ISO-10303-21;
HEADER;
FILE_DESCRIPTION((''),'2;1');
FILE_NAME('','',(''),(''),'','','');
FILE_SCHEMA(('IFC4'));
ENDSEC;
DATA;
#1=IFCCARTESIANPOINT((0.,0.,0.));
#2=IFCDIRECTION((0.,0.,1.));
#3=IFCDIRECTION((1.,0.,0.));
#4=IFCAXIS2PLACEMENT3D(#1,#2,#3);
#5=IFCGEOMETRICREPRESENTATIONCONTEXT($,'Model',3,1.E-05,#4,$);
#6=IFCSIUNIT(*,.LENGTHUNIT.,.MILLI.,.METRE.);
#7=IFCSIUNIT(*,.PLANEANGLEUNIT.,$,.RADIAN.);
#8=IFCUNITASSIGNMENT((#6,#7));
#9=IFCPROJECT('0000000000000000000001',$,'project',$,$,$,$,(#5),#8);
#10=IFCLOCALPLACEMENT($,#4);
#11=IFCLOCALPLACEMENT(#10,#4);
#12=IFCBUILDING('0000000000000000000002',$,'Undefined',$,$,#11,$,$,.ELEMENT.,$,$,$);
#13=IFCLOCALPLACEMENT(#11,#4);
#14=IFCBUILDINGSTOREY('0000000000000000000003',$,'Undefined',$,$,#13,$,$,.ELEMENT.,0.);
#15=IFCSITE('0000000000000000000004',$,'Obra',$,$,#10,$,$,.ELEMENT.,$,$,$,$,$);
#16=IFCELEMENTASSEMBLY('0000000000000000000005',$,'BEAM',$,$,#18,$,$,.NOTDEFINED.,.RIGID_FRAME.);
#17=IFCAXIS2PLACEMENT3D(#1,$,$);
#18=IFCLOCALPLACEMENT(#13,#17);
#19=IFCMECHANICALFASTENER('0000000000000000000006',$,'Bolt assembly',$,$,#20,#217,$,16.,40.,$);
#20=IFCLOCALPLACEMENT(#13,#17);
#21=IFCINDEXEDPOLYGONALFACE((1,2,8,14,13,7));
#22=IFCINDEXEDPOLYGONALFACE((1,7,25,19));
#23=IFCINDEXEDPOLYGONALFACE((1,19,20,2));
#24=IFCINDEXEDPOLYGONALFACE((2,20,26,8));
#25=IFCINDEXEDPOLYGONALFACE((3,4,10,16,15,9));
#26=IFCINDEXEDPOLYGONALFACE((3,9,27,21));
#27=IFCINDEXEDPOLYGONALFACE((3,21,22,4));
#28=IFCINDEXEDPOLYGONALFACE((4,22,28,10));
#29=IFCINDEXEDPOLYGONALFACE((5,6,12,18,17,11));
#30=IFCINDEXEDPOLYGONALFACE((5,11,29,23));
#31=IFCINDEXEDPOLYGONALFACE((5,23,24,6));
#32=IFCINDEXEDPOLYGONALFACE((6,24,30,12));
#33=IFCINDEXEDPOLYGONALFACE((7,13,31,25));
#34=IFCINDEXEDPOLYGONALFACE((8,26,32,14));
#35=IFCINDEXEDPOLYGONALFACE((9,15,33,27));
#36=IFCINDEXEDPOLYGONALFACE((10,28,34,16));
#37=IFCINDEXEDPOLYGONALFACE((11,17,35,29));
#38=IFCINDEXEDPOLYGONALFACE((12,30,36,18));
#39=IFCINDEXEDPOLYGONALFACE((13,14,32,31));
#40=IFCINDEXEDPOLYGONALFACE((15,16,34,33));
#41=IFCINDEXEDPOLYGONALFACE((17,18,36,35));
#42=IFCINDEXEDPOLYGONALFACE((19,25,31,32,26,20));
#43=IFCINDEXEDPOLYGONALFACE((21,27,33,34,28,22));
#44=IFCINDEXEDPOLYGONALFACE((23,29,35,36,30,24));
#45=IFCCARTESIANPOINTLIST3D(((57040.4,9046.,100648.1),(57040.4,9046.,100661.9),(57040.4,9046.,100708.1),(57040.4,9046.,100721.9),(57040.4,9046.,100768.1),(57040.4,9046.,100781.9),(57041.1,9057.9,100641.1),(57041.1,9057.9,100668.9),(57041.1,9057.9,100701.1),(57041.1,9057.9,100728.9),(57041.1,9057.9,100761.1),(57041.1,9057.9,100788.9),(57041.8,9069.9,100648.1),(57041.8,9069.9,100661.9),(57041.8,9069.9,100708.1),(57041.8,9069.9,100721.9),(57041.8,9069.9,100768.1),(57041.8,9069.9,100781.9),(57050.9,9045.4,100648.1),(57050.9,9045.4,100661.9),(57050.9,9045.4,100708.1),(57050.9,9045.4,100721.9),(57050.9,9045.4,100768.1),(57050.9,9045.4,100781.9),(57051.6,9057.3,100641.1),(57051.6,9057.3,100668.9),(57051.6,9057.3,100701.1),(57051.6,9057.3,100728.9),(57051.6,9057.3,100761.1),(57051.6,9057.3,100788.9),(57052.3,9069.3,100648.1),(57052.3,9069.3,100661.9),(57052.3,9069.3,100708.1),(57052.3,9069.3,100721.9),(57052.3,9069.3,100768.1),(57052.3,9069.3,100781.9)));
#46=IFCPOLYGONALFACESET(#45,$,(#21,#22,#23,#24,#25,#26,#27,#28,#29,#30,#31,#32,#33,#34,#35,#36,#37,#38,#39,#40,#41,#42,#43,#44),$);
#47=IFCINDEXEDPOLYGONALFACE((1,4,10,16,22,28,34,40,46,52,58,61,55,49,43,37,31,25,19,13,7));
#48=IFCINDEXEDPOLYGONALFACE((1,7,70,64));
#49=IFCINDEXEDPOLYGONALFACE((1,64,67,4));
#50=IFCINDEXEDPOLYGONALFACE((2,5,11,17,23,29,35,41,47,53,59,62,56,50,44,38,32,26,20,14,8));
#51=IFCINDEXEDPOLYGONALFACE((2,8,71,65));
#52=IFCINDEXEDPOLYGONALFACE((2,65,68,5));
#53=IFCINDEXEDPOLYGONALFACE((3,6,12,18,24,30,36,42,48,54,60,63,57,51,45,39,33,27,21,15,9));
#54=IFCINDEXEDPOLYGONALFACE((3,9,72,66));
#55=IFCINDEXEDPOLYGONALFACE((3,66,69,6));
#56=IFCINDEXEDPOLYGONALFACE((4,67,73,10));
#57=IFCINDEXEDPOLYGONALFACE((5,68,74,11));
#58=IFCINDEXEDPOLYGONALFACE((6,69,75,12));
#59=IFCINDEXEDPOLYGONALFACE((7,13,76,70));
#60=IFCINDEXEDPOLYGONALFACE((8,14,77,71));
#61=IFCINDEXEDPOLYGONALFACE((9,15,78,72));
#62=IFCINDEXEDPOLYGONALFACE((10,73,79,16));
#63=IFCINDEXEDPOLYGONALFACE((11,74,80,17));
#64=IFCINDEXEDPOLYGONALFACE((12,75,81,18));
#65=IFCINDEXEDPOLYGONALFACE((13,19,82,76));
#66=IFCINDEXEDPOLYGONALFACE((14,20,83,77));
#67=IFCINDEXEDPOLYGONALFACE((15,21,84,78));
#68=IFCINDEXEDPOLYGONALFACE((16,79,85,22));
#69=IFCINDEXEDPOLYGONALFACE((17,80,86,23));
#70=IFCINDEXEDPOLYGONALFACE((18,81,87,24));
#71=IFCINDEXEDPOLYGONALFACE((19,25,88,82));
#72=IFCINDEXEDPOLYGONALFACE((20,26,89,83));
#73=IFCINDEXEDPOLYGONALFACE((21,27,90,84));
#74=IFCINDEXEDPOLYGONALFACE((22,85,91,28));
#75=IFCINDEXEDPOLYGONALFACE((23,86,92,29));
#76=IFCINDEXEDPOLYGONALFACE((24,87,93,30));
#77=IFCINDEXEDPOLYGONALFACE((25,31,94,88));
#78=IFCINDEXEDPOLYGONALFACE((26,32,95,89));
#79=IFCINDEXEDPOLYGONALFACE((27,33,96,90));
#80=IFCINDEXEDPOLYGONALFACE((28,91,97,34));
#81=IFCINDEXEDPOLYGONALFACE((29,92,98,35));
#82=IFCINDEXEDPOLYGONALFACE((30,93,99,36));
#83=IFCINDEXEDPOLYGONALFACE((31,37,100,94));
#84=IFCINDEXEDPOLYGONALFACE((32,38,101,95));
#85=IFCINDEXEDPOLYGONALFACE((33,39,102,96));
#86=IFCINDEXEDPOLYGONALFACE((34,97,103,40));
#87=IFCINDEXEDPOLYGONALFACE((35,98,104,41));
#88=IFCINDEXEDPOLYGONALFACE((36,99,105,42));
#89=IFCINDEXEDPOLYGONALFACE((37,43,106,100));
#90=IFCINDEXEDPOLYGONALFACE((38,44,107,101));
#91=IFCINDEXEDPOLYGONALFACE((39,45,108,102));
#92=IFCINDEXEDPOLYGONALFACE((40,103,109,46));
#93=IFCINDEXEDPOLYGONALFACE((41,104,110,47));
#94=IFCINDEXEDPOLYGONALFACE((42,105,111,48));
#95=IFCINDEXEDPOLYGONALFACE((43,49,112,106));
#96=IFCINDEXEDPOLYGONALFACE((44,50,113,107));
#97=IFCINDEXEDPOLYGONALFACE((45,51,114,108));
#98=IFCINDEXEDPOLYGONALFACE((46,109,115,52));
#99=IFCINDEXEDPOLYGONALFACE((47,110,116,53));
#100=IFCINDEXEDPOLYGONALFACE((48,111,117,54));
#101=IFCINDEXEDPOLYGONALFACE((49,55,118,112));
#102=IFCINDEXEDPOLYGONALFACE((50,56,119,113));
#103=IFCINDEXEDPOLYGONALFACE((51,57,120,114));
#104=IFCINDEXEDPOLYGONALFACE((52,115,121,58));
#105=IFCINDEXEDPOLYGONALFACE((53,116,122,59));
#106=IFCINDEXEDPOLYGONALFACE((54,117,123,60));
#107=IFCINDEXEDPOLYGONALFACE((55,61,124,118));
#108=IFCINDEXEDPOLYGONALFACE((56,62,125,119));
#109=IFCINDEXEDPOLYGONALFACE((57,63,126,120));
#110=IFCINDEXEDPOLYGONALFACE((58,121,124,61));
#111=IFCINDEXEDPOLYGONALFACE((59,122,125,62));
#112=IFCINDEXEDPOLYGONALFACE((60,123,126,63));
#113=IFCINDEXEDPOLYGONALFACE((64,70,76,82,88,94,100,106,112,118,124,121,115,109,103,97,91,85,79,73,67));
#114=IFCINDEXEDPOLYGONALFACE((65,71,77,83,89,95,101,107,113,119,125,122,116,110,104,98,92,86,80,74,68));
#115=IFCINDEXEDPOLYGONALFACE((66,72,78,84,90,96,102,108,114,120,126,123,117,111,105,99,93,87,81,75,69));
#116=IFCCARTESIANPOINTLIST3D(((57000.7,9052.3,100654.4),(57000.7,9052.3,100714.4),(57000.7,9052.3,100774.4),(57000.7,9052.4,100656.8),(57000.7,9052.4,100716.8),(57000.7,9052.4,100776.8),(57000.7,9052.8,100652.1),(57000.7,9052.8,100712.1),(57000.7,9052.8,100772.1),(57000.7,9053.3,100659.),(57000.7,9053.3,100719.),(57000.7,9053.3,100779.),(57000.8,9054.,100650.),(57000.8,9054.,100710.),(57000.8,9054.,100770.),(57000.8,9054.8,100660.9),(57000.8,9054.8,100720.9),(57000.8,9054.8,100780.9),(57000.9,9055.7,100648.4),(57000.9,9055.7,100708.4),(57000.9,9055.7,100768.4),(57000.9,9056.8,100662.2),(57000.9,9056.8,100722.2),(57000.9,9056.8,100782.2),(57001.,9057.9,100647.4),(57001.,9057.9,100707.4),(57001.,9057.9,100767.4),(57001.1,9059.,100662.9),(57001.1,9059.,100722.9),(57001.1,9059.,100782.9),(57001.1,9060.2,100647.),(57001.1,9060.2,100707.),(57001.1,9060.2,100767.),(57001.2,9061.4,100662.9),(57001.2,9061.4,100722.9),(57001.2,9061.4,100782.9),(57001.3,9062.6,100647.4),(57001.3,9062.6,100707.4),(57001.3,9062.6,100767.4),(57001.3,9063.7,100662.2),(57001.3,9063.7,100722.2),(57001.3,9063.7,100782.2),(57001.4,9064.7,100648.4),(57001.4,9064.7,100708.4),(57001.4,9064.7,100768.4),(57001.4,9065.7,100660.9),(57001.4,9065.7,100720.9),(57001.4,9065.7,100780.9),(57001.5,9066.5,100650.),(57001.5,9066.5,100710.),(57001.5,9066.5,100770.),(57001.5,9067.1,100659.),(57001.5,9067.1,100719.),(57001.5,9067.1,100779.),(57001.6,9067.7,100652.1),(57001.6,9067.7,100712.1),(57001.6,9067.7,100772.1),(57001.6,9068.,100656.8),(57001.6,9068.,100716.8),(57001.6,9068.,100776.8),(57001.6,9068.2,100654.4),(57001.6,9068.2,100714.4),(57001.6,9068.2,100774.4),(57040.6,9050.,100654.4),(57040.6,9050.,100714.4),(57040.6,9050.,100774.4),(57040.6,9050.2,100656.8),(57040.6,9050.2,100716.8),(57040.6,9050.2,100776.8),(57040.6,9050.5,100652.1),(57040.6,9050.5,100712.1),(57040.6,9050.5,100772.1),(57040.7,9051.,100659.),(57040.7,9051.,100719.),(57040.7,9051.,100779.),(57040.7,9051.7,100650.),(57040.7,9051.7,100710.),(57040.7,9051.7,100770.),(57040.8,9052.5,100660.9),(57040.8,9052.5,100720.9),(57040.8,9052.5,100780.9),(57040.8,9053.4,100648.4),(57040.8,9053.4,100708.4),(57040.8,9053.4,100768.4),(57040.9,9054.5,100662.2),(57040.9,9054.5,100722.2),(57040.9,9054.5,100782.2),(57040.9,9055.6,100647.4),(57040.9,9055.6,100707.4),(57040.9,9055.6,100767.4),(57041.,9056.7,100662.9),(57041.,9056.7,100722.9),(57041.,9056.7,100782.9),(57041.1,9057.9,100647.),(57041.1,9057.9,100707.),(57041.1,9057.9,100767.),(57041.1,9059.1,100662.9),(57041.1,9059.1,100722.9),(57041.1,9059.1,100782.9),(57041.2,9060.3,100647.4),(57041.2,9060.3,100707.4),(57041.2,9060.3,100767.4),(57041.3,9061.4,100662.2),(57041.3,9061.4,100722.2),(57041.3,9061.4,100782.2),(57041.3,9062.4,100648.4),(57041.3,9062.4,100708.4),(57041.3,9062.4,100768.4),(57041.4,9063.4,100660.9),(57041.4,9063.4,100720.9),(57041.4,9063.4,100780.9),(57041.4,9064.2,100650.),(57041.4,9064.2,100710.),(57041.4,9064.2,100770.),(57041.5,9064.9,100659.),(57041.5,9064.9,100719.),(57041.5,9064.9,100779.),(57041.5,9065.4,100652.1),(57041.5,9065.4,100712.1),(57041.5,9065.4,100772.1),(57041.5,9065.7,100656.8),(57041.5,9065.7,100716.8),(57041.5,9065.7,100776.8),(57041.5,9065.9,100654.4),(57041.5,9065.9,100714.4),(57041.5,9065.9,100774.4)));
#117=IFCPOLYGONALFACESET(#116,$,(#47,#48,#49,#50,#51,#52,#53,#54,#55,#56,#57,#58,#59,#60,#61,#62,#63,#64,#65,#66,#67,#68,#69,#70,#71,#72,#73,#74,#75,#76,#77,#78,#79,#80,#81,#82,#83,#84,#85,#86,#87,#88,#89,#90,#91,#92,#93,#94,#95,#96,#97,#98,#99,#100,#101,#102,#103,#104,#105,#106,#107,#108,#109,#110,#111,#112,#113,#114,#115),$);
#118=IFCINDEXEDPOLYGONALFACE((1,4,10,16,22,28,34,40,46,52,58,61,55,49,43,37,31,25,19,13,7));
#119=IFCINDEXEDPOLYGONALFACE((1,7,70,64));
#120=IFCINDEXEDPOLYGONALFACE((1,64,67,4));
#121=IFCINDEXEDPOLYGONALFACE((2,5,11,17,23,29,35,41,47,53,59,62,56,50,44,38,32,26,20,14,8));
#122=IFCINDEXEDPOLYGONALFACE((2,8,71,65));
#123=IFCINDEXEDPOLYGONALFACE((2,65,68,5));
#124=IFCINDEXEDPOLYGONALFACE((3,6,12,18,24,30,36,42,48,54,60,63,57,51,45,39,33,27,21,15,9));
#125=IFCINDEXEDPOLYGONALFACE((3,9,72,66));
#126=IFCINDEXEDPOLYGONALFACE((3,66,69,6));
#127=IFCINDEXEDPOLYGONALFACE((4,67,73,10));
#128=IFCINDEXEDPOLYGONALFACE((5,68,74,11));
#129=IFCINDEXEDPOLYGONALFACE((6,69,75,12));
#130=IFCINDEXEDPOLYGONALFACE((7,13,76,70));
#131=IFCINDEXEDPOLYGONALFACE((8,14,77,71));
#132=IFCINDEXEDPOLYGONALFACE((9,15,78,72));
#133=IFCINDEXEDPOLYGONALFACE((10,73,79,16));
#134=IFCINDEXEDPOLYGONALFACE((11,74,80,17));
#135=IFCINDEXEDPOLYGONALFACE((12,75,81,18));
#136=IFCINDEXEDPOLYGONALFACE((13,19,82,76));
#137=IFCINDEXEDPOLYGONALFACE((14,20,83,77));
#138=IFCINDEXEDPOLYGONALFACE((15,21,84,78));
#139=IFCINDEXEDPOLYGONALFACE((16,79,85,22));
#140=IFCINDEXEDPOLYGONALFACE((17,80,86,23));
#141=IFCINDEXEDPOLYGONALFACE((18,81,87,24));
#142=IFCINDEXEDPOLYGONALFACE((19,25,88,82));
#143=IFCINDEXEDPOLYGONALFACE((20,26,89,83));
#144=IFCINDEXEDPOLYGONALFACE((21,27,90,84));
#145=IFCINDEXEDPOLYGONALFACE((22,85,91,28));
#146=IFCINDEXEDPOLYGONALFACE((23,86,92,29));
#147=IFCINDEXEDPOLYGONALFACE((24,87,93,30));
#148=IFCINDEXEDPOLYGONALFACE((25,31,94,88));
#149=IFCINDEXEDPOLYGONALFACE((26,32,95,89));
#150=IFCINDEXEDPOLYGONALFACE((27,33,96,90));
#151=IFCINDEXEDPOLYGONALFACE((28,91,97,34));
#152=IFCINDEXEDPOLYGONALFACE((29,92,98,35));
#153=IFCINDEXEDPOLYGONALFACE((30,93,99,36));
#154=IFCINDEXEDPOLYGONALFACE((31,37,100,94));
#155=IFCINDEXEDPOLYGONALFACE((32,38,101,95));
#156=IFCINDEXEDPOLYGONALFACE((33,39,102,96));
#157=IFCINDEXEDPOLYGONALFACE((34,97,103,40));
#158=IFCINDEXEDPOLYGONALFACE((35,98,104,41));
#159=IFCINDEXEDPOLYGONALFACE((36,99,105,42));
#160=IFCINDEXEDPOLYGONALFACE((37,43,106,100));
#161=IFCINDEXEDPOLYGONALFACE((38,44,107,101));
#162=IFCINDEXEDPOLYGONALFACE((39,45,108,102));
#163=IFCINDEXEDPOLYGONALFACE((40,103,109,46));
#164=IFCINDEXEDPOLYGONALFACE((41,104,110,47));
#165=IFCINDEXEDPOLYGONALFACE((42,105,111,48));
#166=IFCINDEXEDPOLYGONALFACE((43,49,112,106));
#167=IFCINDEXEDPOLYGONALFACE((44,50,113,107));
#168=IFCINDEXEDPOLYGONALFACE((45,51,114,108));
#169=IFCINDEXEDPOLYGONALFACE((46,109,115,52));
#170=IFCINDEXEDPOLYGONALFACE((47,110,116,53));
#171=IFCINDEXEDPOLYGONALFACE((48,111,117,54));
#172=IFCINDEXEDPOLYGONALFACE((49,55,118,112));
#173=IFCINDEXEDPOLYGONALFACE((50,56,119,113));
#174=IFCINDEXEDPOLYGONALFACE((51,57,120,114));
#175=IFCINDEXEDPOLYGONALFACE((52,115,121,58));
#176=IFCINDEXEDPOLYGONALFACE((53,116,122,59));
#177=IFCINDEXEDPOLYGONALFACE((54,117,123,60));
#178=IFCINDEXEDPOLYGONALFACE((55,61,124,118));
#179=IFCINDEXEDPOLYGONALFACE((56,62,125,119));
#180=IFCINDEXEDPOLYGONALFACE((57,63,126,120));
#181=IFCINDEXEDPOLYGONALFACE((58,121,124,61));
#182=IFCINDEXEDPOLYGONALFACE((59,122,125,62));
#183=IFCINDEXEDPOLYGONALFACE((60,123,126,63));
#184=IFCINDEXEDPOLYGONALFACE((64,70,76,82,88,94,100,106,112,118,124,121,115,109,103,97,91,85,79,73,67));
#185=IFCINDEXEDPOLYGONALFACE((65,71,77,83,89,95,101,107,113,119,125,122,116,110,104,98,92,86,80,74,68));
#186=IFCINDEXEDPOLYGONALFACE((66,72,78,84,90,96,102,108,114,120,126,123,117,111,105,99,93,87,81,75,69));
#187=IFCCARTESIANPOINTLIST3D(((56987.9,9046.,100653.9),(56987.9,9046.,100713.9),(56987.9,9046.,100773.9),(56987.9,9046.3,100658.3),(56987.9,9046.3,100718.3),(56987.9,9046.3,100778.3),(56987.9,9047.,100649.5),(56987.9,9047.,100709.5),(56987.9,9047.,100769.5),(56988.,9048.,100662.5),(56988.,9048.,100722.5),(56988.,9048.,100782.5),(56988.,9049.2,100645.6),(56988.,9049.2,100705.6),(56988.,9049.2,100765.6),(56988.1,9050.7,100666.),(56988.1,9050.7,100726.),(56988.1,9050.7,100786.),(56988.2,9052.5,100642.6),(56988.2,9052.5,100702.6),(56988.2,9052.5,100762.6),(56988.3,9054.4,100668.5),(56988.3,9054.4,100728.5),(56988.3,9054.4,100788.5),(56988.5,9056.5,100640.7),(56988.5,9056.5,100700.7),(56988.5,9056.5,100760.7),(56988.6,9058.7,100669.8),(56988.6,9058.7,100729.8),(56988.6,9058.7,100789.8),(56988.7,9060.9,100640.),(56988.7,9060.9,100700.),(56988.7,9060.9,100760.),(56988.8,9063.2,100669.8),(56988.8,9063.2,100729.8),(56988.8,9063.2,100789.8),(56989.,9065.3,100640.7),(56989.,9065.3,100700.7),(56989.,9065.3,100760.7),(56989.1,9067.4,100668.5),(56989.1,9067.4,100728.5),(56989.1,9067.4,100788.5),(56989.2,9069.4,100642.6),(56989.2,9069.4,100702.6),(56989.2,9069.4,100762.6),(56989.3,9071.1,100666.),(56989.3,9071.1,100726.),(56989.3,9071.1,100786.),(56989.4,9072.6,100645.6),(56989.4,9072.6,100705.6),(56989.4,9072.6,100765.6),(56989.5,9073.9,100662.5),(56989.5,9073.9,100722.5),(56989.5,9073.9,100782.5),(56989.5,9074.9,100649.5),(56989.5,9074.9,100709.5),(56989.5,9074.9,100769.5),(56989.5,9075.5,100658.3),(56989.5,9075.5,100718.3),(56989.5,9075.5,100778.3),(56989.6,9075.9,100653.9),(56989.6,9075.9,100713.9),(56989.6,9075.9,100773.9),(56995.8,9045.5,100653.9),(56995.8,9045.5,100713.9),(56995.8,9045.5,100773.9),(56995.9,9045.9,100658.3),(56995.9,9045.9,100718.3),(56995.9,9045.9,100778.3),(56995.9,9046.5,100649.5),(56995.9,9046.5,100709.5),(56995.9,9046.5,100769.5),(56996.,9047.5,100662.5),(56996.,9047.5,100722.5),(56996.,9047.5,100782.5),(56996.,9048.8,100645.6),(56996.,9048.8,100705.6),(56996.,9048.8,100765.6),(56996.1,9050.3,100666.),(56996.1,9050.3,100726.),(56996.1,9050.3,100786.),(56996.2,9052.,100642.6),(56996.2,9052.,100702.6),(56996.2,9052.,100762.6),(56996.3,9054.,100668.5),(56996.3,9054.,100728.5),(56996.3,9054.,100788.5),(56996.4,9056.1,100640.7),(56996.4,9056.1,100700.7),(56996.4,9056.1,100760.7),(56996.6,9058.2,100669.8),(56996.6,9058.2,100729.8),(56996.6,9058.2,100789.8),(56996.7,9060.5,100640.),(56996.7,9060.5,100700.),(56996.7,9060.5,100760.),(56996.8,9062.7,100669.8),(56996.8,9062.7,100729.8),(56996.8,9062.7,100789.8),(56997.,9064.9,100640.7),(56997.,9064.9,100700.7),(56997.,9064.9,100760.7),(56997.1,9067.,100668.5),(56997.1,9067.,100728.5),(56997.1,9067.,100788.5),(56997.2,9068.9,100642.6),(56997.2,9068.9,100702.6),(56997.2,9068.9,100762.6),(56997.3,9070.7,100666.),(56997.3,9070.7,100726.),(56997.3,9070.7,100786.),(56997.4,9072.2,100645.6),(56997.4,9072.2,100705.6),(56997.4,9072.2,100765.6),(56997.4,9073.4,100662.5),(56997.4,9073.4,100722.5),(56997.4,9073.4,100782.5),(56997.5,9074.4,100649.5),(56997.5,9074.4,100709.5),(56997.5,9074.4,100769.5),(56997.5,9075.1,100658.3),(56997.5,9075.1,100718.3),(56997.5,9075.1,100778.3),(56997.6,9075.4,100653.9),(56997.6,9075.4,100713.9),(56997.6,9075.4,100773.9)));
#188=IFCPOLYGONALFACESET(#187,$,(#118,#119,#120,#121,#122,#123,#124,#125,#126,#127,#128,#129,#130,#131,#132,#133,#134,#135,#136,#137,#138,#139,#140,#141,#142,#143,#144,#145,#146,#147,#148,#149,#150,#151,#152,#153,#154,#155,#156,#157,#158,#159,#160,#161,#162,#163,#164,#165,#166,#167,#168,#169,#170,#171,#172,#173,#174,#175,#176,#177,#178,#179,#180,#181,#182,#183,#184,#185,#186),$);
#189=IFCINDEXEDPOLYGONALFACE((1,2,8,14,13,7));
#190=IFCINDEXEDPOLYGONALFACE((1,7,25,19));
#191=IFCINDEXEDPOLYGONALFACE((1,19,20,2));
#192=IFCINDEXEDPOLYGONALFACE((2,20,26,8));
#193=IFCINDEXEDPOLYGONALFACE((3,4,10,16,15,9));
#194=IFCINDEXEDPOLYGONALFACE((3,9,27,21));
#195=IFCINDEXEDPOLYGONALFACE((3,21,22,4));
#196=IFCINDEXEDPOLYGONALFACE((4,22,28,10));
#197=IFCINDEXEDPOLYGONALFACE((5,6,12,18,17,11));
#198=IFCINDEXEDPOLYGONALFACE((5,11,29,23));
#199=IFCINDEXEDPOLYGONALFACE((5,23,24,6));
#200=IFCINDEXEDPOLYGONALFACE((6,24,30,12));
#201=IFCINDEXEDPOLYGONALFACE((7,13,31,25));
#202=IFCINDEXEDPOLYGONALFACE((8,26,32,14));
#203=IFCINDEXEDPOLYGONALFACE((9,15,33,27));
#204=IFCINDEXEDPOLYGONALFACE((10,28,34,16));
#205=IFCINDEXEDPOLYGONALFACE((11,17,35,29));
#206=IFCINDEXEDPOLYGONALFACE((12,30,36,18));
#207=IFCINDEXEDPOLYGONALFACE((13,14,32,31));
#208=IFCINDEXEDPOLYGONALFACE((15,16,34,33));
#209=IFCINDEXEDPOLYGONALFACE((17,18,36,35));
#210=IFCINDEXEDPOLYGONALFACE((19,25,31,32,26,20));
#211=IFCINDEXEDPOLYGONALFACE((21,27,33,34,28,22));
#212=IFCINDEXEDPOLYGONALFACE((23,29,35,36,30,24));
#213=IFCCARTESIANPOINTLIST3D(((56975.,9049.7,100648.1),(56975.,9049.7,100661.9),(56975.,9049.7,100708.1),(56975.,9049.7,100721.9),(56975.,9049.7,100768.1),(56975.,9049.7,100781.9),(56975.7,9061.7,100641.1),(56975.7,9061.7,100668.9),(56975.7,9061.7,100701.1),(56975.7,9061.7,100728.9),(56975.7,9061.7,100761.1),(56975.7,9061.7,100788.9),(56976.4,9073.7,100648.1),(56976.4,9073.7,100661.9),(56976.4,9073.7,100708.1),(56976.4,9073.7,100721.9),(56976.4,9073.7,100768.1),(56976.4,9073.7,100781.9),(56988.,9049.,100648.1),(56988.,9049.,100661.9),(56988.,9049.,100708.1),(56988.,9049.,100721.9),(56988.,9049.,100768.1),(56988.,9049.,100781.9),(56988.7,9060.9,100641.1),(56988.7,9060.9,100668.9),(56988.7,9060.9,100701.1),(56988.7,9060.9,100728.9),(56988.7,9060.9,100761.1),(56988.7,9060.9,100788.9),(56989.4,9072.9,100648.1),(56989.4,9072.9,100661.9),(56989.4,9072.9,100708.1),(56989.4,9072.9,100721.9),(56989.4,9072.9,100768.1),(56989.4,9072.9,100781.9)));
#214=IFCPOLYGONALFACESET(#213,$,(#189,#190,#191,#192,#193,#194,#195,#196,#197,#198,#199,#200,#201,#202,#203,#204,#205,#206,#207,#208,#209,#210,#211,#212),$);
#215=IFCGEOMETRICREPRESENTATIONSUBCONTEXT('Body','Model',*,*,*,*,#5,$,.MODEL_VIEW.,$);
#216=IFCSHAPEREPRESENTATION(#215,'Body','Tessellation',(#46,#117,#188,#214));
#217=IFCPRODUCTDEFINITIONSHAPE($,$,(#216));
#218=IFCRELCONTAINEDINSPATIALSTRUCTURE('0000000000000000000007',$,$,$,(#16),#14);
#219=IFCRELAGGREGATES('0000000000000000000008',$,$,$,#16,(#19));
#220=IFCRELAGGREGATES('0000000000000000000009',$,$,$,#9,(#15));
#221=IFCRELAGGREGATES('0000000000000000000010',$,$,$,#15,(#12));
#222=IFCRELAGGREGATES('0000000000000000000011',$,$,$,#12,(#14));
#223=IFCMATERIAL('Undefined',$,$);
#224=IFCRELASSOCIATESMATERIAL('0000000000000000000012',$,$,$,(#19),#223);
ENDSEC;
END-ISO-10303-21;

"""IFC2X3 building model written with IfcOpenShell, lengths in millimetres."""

from ifc_helpers import new_model, si_unit, frame, origin_with_axes, origin_2d_with_axis, place, context, subcontext, project, spatial, polyline, circle, outline, extrude, source, transform, mapped, material, element, aggregate, save


model = new_model("IFC2X3")

# Units and contexts
model_context = context("Model", 3, precision=1e-05, world=origin_with_axes())
body_context = subcontext(model_context, "Body", "Model", "MODEL_VIEW")
ifc_project = project(units=[si_unit("LENGTHUNIT", "METRE", prefix="MILLI"), si_unit("PLANEANGLEUNIT", "RADIAN")], contexts=[model_context])

# Site, building, storey
site_placement = place(None, origin_with_axes())
site = spatial("IfcSite", under=ifc_project, at=site_placement, Name="Obra", CompositionType="ELEMENT")
building_placement = place(site_placement, origin_with_axes())
building = spatial("IfcBuilding", under=site, at=building_placement, Name="Undefined", CompositionType="ELEMENT")
storey_placement = place(building_placement, origin_with_axes())
storey = spatial("IfcBuildingStorey", under=building, at=storey_placement, Name="Undefined", CompositionType="ELEMENT", Elevation=0.0)

# Shared definitions
ifc_material_1 = material(Name="Undefined")

# Element assembly, mechanical fastener
shared_shape_1 = source(origin_with_axes(), body_context, "Body", "SweptSolid", [
    extrude(outline(polyline([(13.9, 0.0), (6.9, 12.0), (-6.9, 12.0), (-13.9, 0.0), (-6.9, -12.0), (6.9, -12.0), (13.9, 0.0)])), frame((0.0, -19.7, 0.0), z_axis=(0.0, 1.0, 0.0), x_axis=(1.0, 0.0, 0.0)), (0.0, 0.0, 1.0), 10.6),
    extrude(circle(Radius=8.0, at=origin_2d_with_axis()), frame((0.0, -9.1, 0.0), z_axis=(0.0, 1.0, 0.0), x_axis=(1.0, 0.0, 0.0)), (0.0, 0.0, 1.0), 40.0),
    extrude(circle(Radius=15.0, at=origin_2d_with_axis()), frame((0.0, 35.3, 0.0), z_axis=(0.0, 1.0, 0.0), x_axis=(1.0, 0.0, 0.0)), (0.0, 0.0, 1.0), 8.0),
    extrude(outline(polyline([(13.9, 0.0), (6.9, 12.0), (-6.9, 12.0), (-13.9, 0.0), (-6.9, -12.0), (6.9, -12.0), (13.9, 0.0)])), frame((0.0, 43.3, 0.0), z_axis=(0.0, 1.0, 0.0), x_axis=(1.0, 0.0, 0.0)), (0.0, 0.0, 1.0), 13.0),
])
assembly_1_placement = place(storey_placement, origin_with_axes())
assembly_1 = element("IfcElementAssembly", 1, at=assembly_1_placement, inside=storey, Name="BEAM", AssemblyPlace="NOTDEFINED", PredefinedType="RIGID_FRAME")
mechanical_fastener_1_placement = place(assembly_1_placement, frame((57029.1, 9008.5, 100835.0), z_axis=(0.05711, 0.998368, 0.0), x_axis=(0.0, 0.0, -1.0)))
mechanical_fastener_1 = element("IfcMechanicalFastener", 2, at=mechanical_fastener_1_placement, material=ifc_material_1, Name="Bolt assembly", NominalDiameter=16.0, NominalLength=40.0, context=body_context, shape_type="MappedRepresentation", body=[
    mapped(shared_shape_1, transform((60.0, 0.0, 50.0))),
    mapped(shared_shape_1, transform((120.0, 0.0, 50.0))),
    mapped(shared_shape_1, transform((180.0, 0.0, 50.0))),
])

aggregate(assembly_1, [mechanical_fastener_1])

save(model, "model.ifc")
